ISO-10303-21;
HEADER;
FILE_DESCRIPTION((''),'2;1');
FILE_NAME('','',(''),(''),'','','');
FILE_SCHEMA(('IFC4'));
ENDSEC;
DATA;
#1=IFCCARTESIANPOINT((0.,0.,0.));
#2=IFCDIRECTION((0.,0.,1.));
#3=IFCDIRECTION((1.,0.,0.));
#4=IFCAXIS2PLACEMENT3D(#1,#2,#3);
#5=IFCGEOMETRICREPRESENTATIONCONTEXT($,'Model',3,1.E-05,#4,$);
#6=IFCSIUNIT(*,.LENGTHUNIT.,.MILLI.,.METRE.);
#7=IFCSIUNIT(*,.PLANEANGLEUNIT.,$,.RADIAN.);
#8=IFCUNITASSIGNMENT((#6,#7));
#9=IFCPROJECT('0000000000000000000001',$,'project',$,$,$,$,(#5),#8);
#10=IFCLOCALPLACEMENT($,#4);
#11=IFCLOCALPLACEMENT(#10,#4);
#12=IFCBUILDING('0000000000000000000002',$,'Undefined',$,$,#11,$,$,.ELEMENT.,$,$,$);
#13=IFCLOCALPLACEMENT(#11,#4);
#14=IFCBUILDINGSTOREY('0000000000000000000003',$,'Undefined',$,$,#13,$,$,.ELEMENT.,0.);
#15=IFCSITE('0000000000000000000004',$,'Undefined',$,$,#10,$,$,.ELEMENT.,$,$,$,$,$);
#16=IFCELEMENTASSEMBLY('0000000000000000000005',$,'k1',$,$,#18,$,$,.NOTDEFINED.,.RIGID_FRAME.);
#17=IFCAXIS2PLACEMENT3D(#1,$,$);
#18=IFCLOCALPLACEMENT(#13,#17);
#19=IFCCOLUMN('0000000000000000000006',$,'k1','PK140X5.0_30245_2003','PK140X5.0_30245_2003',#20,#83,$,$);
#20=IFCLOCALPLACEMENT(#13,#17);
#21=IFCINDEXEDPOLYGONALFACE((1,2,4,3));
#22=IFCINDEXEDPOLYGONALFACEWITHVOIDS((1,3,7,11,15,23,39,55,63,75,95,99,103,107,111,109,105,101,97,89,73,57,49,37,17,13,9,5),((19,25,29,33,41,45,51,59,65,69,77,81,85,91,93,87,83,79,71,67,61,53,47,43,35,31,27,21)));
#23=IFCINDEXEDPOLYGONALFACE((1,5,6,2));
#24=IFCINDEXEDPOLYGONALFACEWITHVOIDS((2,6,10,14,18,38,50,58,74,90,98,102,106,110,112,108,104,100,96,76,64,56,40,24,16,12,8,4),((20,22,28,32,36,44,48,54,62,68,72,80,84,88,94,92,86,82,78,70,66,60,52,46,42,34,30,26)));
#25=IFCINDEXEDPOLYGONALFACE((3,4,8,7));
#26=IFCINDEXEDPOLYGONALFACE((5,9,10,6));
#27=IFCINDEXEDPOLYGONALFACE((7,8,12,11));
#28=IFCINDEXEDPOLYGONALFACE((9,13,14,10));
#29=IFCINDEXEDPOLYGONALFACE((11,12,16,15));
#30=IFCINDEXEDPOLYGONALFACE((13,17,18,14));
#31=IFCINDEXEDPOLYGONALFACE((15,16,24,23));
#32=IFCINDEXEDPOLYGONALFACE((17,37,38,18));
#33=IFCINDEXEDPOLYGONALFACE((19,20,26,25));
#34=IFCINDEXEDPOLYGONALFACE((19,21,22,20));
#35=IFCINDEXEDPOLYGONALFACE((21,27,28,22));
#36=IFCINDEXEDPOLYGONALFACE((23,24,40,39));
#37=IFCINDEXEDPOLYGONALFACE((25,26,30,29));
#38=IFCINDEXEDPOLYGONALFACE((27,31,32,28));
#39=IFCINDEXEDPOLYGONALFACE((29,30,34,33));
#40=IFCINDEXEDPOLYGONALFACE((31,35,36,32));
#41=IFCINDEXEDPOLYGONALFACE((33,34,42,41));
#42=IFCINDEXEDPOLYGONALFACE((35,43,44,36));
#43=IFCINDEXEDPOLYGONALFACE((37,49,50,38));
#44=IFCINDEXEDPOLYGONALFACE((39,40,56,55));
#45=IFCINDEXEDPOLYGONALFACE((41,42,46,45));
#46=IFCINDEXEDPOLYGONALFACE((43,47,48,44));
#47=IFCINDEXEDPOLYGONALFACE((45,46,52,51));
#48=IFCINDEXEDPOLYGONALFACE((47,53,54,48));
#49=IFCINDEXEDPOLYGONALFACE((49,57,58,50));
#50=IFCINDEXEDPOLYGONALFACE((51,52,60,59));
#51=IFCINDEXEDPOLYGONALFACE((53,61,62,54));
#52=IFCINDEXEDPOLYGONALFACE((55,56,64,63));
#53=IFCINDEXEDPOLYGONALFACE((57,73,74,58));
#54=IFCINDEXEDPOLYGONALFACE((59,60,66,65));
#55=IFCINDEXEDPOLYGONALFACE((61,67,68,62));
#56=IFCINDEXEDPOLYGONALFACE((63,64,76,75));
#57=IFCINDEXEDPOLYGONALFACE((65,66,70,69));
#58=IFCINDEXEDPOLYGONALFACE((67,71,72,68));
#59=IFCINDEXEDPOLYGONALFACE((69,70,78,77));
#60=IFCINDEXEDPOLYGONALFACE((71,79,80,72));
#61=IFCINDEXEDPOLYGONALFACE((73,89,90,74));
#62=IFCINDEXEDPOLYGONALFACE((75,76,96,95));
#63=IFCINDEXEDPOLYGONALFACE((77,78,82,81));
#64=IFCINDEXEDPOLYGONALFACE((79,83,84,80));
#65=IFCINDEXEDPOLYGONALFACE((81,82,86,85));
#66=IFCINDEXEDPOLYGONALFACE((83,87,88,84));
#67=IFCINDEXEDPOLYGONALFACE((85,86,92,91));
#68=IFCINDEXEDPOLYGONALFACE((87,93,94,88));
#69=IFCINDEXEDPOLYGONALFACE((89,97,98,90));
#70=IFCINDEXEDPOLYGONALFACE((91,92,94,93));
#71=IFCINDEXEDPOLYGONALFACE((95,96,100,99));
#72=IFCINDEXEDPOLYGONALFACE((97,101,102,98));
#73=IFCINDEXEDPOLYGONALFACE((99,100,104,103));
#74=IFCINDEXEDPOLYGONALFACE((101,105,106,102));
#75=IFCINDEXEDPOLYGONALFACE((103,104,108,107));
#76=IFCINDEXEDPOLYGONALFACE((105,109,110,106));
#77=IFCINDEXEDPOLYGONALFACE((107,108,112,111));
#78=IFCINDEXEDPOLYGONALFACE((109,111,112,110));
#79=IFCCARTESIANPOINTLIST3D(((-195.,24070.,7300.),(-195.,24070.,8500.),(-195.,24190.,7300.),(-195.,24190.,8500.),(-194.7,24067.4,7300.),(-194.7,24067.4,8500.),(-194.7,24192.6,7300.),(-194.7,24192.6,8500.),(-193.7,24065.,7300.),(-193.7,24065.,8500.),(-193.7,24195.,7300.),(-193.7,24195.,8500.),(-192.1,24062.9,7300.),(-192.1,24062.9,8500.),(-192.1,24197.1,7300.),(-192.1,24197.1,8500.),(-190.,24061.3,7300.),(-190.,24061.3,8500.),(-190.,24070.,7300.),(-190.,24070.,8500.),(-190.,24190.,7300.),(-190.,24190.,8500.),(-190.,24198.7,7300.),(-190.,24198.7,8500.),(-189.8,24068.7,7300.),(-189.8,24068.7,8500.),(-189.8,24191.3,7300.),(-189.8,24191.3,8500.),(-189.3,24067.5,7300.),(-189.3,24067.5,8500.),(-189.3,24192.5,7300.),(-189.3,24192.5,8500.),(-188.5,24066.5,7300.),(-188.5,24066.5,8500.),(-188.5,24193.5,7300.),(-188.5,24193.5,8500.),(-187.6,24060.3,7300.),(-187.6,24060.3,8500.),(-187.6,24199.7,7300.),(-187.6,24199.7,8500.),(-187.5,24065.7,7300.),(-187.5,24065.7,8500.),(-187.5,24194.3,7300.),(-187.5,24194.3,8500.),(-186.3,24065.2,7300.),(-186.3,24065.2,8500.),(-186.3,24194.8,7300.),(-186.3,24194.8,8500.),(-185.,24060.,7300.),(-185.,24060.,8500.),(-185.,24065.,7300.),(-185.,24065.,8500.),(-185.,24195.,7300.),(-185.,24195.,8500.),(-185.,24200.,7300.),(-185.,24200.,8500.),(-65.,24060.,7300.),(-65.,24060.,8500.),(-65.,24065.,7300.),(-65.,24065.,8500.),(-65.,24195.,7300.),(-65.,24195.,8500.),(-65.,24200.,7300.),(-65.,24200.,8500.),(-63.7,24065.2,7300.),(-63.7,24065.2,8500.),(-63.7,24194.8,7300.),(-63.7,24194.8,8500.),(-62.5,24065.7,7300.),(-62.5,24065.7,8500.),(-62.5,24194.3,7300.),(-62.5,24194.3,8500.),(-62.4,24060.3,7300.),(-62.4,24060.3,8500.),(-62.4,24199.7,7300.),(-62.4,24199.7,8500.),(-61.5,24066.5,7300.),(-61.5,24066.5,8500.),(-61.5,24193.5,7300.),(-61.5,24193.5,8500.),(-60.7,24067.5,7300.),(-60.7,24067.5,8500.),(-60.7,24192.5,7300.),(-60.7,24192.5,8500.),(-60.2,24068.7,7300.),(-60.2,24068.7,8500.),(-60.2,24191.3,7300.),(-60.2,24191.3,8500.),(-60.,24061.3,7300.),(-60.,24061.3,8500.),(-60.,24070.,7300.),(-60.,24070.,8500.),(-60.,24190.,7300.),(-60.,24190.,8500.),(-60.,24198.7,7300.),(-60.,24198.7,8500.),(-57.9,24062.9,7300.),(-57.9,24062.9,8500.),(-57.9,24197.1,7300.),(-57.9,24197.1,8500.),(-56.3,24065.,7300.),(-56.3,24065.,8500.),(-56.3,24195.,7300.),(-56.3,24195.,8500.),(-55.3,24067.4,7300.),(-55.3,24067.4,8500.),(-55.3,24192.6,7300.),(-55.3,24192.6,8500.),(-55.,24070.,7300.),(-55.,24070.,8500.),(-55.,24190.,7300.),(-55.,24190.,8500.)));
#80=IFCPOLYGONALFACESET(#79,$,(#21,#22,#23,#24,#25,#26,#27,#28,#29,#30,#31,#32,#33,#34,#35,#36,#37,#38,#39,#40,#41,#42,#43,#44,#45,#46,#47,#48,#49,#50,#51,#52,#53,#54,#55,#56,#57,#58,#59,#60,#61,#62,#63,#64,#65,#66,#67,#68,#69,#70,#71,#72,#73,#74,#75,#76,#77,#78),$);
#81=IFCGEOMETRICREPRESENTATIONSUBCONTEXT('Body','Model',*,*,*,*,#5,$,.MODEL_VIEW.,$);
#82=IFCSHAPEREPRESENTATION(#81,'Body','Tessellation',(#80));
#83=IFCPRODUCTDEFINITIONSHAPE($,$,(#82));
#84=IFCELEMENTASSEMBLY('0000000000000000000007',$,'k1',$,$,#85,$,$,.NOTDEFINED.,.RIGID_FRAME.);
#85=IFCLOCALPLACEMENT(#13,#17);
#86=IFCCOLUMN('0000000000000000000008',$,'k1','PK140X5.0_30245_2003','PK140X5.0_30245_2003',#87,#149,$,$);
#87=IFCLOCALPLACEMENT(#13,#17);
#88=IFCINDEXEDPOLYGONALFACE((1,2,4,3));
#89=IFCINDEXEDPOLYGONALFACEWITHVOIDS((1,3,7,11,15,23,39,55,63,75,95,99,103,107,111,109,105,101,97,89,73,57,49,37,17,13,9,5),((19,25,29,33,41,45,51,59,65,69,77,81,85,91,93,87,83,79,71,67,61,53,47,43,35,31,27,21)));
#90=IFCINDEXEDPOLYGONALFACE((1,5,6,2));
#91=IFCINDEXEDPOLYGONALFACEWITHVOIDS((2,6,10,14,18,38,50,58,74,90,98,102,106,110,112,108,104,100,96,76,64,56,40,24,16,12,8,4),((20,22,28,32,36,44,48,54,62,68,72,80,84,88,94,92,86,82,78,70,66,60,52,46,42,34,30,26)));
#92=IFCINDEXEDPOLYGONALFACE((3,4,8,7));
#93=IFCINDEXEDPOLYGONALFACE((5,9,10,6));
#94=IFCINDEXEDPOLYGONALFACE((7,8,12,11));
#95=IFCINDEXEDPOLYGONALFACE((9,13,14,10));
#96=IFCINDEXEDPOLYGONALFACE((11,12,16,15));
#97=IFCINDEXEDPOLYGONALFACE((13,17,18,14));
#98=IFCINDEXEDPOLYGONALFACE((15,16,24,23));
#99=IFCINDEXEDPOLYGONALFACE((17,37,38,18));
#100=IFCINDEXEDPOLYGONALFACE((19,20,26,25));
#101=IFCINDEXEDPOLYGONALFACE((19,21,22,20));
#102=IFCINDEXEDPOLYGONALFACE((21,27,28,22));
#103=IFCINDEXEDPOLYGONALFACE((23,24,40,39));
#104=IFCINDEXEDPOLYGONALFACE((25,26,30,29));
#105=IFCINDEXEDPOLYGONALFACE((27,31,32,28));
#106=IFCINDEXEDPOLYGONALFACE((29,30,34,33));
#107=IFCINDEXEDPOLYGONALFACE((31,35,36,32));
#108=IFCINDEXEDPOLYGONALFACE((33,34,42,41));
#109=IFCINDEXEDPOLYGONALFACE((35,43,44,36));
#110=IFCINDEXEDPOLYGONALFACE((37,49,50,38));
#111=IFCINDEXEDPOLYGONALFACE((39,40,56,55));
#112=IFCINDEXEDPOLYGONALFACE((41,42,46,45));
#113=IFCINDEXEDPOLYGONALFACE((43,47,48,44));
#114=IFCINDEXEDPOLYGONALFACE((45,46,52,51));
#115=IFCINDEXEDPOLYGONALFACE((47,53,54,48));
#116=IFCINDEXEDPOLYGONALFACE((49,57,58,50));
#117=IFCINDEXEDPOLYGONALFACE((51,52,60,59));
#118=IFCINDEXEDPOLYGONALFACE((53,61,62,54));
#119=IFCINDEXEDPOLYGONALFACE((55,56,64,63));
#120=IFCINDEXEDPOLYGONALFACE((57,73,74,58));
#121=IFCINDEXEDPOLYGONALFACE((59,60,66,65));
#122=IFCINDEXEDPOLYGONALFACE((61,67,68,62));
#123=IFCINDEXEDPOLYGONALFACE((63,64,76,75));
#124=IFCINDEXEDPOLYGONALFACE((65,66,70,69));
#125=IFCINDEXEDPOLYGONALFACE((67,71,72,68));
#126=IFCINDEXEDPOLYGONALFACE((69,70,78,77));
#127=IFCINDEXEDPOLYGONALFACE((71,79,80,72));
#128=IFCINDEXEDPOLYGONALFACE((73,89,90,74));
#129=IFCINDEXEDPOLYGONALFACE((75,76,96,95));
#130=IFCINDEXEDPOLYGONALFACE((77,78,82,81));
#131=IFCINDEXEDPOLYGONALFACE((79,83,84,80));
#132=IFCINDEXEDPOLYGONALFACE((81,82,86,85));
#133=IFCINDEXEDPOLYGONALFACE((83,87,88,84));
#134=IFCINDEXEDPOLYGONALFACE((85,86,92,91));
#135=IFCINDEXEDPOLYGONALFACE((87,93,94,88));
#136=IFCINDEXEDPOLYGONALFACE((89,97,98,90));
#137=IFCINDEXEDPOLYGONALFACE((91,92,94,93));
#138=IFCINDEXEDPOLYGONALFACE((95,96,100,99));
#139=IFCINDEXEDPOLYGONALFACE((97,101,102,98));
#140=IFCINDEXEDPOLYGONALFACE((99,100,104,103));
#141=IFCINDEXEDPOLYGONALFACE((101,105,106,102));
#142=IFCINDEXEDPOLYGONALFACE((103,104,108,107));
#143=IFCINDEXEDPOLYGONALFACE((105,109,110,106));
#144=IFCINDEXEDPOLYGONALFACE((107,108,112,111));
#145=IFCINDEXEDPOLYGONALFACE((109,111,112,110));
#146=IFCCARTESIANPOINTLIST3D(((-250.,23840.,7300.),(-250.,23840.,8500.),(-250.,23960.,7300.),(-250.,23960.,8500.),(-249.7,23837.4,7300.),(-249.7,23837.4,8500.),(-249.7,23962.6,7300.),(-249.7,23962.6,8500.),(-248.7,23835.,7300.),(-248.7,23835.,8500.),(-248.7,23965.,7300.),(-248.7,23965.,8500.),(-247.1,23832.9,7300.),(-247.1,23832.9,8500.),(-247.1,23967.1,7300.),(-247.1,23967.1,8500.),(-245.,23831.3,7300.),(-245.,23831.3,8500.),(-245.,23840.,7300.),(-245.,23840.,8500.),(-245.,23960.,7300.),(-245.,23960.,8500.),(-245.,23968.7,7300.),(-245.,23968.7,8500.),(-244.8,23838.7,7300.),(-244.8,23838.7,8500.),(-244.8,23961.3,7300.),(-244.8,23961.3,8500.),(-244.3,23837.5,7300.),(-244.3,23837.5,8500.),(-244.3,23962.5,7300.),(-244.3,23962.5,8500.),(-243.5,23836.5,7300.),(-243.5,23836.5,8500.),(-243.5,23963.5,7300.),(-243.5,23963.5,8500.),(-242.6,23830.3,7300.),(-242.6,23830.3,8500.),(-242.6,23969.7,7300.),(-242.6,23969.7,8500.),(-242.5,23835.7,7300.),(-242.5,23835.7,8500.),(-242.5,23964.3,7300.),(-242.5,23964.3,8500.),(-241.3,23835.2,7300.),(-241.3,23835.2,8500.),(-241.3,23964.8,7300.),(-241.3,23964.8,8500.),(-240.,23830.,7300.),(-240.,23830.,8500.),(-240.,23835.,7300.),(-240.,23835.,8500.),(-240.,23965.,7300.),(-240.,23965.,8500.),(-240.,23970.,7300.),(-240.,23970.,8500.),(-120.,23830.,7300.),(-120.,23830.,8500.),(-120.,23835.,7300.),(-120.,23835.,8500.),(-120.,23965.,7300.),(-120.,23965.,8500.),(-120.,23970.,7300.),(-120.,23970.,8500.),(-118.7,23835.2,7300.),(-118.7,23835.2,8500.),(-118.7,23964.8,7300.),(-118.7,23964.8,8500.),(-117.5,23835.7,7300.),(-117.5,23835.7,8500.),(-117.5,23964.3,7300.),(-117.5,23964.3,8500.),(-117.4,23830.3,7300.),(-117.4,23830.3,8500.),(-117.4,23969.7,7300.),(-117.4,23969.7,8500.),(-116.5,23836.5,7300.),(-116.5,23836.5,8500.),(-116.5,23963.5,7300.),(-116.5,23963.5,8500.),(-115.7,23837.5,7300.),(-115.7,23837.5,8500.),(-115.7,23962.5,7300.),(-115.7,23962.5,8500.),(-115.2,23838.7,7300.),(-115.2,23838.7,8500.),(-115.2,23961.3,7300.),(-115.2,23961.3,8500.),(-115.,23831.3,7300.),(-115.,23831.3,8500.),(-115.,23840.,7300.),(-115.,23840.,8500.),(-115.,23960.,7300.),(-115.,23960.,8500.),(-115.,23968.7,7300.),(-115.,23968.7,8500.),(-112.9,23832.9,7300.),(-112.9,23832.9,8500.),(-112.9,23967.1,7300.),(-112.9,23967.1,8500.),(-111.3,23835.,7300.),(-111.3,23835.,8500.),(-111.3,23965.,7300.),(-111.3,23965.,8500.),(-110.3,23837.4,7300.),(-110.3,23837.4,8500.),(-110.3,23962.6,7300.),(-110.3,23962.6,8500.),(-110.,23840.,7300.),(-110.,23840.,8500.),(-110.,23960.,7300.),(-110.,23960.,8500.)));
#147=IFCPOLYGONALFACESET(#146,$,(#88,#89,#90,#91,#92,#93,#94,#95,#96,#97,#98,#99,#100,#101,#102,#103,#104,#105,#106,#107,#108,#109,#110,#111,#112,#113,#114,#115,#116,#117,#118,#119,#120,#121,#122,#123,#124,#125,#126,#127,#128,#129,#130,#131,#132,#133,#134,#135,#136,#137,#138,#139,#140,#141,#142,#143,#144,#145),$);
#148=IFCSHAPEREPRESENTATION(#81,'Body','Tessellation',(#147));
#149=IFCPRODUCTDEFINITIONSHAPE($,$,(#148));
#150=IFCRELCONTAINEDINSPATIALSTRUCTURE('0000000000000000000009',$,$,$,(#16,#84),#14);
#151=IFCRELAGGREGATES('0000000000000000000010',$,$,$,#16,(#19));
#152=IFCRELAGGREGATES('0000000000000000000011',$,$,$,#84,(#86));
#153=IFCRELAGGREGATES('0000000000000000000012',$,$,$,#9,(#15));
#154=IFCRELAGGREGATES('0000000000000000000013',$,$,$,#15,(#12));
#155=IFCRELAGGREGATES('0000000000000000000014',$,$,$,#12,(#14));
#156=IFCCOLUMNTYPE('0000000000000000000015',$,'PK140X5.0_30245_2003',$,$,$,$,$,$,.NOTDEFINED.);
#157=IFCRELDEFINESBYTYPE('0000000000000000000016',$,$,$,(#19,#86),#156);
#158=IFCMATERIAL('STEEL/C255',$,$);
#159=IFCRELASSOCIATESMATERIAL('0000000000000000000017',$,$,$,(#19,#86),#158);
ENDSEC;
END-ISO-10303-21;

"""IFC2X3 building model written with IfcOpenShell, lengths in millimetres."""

from ifc_helpers import new_model, si_unit, frame, origin_with_axes, origin_2d_with_axis, place, context, subcontext, project, spatial, hollow_rectangle, extrude, material, type_object, element, aggregate, save


model = new_model("IFC2X3")

# Units and contexts
model_context = context("Model", 3, precision=1e-05, world=origin_with_axes())
body_context = subcontext(model_context, "Body", "Model", "MODEL_VIEW")
ifc_project = project(units=[si_unit("LENGTHUNIT", "METRE", prefix="MILLI"), si_unit("PLANEANGLEUNIT", "RADIAN")], contexts=[model_context])

# Site, building, storey
site_placement = place(None, origin_with_axes())
site = spatial("IfcSite", under=ifc_project, at=site_placement, Name="Undefined", CompositionType="ELEMENT")
building_placement = place(site_placement, origin_with_axes())
building = spatial("IfcBuilding", under=site, at=building_placement, Name="Undefined", CompositionType="ELEMENT")
storey_placement = place(building_placement, origin_with_axes())
storey = spatial("IfcBuildingStorey", under=building, at=storey_placement, Name="Undefined", CompositionType="ELEMENT", Elevation=0.0)

# Element assemblies, columns
assembly_1_placement = place(storey_placement, origin_with_axes())
assembly_1 = element("IfcElementAssembly", 1, at=assembly_1_placement, inside=storey, Name="k1", AssemblyPlace="NOTDEFINED", PredefinedType="RIGID_FRAME")
ifc_material_1 = material(Name="STEEL/C255")
column_type_1 = type_object("IfcColumnType", Name="PK140X5.0_30245_2003", PredefinedType="NOTDEFINED")
column_1_placement = place(assembly_1_placement, frame((-125.0, 24130.0, 7300.0), z_axis=(0.0, 0.0, 1.0), x_axis=(0.0, -1.0, 0.0)))
column_1 = element("IfcColumn", 2, at=column_1_placement, type_object=column_type_1, material=ifc_material_1, Name="k1", Description="PK140X5.0_30245_2003", ObjectType="PK140X5.0_30245_2003", context=body_context, shape_type="SweptSolid", body=[
    extrude(hollow_rectangle(XDim=140.0, YDim=140.0, WallThickness=5.0, InnerFilletRadius=5.0, OuterFilletRadius=10.0, at=origin_2d_with_axis()), frame((0.0, 0.0, 1200.0), z_axis=(0.0, 0.0, -1.0), x_axis=(0.0, 1.0, 0.0)), (0.0, 0.0, 1.0), 1200.0),
])
aggregate(assembly_1, [column_1])
assembly_2_placement = place(storey_placement, origin_with_axes())
assembly_2 = element("IfcElementAssembly", 3, at=assembly_2_placement, inside=storey, Name="k1", AssemblyPlace="NOTDEFINED", PredefinedType="RIGID_FRAME")
column_2_placement = place(assembly_2_placement, frame((-180.0, 23900.0, 7300.0), z_axis=(0.0, 0.0, 1.0), x_axis=(1.0, 0.0, 0.0)))
column_2 = element("IfcColumn", 4, at=column_2_placement, type_object=column_type_1, material=ifc_material_1, Name="k1", Description="PK140X5.0_30245_2003", ObjectType="PK140X5.0_30245_2003", context=body_context, shape_type="SweptSolid", body=[
    extrude(hollow_rectangle(XDim=140.0, YDim=140.0, WallThickness=5.0, InnerFilletRadius=5.0, OuterFilletRadius=10.0, at=origin_2d_with_axis()), frame((0.0, 0.0, 1200.0), z_axis=(0.0, 0.0, -1.0), x_axis=(0.0, 1.0, 0.0)), (0.0, 0.0, 1.0), 1200.0),
])
aggregate(assembly_2, [column_2])

save(model, "model.ifc")
